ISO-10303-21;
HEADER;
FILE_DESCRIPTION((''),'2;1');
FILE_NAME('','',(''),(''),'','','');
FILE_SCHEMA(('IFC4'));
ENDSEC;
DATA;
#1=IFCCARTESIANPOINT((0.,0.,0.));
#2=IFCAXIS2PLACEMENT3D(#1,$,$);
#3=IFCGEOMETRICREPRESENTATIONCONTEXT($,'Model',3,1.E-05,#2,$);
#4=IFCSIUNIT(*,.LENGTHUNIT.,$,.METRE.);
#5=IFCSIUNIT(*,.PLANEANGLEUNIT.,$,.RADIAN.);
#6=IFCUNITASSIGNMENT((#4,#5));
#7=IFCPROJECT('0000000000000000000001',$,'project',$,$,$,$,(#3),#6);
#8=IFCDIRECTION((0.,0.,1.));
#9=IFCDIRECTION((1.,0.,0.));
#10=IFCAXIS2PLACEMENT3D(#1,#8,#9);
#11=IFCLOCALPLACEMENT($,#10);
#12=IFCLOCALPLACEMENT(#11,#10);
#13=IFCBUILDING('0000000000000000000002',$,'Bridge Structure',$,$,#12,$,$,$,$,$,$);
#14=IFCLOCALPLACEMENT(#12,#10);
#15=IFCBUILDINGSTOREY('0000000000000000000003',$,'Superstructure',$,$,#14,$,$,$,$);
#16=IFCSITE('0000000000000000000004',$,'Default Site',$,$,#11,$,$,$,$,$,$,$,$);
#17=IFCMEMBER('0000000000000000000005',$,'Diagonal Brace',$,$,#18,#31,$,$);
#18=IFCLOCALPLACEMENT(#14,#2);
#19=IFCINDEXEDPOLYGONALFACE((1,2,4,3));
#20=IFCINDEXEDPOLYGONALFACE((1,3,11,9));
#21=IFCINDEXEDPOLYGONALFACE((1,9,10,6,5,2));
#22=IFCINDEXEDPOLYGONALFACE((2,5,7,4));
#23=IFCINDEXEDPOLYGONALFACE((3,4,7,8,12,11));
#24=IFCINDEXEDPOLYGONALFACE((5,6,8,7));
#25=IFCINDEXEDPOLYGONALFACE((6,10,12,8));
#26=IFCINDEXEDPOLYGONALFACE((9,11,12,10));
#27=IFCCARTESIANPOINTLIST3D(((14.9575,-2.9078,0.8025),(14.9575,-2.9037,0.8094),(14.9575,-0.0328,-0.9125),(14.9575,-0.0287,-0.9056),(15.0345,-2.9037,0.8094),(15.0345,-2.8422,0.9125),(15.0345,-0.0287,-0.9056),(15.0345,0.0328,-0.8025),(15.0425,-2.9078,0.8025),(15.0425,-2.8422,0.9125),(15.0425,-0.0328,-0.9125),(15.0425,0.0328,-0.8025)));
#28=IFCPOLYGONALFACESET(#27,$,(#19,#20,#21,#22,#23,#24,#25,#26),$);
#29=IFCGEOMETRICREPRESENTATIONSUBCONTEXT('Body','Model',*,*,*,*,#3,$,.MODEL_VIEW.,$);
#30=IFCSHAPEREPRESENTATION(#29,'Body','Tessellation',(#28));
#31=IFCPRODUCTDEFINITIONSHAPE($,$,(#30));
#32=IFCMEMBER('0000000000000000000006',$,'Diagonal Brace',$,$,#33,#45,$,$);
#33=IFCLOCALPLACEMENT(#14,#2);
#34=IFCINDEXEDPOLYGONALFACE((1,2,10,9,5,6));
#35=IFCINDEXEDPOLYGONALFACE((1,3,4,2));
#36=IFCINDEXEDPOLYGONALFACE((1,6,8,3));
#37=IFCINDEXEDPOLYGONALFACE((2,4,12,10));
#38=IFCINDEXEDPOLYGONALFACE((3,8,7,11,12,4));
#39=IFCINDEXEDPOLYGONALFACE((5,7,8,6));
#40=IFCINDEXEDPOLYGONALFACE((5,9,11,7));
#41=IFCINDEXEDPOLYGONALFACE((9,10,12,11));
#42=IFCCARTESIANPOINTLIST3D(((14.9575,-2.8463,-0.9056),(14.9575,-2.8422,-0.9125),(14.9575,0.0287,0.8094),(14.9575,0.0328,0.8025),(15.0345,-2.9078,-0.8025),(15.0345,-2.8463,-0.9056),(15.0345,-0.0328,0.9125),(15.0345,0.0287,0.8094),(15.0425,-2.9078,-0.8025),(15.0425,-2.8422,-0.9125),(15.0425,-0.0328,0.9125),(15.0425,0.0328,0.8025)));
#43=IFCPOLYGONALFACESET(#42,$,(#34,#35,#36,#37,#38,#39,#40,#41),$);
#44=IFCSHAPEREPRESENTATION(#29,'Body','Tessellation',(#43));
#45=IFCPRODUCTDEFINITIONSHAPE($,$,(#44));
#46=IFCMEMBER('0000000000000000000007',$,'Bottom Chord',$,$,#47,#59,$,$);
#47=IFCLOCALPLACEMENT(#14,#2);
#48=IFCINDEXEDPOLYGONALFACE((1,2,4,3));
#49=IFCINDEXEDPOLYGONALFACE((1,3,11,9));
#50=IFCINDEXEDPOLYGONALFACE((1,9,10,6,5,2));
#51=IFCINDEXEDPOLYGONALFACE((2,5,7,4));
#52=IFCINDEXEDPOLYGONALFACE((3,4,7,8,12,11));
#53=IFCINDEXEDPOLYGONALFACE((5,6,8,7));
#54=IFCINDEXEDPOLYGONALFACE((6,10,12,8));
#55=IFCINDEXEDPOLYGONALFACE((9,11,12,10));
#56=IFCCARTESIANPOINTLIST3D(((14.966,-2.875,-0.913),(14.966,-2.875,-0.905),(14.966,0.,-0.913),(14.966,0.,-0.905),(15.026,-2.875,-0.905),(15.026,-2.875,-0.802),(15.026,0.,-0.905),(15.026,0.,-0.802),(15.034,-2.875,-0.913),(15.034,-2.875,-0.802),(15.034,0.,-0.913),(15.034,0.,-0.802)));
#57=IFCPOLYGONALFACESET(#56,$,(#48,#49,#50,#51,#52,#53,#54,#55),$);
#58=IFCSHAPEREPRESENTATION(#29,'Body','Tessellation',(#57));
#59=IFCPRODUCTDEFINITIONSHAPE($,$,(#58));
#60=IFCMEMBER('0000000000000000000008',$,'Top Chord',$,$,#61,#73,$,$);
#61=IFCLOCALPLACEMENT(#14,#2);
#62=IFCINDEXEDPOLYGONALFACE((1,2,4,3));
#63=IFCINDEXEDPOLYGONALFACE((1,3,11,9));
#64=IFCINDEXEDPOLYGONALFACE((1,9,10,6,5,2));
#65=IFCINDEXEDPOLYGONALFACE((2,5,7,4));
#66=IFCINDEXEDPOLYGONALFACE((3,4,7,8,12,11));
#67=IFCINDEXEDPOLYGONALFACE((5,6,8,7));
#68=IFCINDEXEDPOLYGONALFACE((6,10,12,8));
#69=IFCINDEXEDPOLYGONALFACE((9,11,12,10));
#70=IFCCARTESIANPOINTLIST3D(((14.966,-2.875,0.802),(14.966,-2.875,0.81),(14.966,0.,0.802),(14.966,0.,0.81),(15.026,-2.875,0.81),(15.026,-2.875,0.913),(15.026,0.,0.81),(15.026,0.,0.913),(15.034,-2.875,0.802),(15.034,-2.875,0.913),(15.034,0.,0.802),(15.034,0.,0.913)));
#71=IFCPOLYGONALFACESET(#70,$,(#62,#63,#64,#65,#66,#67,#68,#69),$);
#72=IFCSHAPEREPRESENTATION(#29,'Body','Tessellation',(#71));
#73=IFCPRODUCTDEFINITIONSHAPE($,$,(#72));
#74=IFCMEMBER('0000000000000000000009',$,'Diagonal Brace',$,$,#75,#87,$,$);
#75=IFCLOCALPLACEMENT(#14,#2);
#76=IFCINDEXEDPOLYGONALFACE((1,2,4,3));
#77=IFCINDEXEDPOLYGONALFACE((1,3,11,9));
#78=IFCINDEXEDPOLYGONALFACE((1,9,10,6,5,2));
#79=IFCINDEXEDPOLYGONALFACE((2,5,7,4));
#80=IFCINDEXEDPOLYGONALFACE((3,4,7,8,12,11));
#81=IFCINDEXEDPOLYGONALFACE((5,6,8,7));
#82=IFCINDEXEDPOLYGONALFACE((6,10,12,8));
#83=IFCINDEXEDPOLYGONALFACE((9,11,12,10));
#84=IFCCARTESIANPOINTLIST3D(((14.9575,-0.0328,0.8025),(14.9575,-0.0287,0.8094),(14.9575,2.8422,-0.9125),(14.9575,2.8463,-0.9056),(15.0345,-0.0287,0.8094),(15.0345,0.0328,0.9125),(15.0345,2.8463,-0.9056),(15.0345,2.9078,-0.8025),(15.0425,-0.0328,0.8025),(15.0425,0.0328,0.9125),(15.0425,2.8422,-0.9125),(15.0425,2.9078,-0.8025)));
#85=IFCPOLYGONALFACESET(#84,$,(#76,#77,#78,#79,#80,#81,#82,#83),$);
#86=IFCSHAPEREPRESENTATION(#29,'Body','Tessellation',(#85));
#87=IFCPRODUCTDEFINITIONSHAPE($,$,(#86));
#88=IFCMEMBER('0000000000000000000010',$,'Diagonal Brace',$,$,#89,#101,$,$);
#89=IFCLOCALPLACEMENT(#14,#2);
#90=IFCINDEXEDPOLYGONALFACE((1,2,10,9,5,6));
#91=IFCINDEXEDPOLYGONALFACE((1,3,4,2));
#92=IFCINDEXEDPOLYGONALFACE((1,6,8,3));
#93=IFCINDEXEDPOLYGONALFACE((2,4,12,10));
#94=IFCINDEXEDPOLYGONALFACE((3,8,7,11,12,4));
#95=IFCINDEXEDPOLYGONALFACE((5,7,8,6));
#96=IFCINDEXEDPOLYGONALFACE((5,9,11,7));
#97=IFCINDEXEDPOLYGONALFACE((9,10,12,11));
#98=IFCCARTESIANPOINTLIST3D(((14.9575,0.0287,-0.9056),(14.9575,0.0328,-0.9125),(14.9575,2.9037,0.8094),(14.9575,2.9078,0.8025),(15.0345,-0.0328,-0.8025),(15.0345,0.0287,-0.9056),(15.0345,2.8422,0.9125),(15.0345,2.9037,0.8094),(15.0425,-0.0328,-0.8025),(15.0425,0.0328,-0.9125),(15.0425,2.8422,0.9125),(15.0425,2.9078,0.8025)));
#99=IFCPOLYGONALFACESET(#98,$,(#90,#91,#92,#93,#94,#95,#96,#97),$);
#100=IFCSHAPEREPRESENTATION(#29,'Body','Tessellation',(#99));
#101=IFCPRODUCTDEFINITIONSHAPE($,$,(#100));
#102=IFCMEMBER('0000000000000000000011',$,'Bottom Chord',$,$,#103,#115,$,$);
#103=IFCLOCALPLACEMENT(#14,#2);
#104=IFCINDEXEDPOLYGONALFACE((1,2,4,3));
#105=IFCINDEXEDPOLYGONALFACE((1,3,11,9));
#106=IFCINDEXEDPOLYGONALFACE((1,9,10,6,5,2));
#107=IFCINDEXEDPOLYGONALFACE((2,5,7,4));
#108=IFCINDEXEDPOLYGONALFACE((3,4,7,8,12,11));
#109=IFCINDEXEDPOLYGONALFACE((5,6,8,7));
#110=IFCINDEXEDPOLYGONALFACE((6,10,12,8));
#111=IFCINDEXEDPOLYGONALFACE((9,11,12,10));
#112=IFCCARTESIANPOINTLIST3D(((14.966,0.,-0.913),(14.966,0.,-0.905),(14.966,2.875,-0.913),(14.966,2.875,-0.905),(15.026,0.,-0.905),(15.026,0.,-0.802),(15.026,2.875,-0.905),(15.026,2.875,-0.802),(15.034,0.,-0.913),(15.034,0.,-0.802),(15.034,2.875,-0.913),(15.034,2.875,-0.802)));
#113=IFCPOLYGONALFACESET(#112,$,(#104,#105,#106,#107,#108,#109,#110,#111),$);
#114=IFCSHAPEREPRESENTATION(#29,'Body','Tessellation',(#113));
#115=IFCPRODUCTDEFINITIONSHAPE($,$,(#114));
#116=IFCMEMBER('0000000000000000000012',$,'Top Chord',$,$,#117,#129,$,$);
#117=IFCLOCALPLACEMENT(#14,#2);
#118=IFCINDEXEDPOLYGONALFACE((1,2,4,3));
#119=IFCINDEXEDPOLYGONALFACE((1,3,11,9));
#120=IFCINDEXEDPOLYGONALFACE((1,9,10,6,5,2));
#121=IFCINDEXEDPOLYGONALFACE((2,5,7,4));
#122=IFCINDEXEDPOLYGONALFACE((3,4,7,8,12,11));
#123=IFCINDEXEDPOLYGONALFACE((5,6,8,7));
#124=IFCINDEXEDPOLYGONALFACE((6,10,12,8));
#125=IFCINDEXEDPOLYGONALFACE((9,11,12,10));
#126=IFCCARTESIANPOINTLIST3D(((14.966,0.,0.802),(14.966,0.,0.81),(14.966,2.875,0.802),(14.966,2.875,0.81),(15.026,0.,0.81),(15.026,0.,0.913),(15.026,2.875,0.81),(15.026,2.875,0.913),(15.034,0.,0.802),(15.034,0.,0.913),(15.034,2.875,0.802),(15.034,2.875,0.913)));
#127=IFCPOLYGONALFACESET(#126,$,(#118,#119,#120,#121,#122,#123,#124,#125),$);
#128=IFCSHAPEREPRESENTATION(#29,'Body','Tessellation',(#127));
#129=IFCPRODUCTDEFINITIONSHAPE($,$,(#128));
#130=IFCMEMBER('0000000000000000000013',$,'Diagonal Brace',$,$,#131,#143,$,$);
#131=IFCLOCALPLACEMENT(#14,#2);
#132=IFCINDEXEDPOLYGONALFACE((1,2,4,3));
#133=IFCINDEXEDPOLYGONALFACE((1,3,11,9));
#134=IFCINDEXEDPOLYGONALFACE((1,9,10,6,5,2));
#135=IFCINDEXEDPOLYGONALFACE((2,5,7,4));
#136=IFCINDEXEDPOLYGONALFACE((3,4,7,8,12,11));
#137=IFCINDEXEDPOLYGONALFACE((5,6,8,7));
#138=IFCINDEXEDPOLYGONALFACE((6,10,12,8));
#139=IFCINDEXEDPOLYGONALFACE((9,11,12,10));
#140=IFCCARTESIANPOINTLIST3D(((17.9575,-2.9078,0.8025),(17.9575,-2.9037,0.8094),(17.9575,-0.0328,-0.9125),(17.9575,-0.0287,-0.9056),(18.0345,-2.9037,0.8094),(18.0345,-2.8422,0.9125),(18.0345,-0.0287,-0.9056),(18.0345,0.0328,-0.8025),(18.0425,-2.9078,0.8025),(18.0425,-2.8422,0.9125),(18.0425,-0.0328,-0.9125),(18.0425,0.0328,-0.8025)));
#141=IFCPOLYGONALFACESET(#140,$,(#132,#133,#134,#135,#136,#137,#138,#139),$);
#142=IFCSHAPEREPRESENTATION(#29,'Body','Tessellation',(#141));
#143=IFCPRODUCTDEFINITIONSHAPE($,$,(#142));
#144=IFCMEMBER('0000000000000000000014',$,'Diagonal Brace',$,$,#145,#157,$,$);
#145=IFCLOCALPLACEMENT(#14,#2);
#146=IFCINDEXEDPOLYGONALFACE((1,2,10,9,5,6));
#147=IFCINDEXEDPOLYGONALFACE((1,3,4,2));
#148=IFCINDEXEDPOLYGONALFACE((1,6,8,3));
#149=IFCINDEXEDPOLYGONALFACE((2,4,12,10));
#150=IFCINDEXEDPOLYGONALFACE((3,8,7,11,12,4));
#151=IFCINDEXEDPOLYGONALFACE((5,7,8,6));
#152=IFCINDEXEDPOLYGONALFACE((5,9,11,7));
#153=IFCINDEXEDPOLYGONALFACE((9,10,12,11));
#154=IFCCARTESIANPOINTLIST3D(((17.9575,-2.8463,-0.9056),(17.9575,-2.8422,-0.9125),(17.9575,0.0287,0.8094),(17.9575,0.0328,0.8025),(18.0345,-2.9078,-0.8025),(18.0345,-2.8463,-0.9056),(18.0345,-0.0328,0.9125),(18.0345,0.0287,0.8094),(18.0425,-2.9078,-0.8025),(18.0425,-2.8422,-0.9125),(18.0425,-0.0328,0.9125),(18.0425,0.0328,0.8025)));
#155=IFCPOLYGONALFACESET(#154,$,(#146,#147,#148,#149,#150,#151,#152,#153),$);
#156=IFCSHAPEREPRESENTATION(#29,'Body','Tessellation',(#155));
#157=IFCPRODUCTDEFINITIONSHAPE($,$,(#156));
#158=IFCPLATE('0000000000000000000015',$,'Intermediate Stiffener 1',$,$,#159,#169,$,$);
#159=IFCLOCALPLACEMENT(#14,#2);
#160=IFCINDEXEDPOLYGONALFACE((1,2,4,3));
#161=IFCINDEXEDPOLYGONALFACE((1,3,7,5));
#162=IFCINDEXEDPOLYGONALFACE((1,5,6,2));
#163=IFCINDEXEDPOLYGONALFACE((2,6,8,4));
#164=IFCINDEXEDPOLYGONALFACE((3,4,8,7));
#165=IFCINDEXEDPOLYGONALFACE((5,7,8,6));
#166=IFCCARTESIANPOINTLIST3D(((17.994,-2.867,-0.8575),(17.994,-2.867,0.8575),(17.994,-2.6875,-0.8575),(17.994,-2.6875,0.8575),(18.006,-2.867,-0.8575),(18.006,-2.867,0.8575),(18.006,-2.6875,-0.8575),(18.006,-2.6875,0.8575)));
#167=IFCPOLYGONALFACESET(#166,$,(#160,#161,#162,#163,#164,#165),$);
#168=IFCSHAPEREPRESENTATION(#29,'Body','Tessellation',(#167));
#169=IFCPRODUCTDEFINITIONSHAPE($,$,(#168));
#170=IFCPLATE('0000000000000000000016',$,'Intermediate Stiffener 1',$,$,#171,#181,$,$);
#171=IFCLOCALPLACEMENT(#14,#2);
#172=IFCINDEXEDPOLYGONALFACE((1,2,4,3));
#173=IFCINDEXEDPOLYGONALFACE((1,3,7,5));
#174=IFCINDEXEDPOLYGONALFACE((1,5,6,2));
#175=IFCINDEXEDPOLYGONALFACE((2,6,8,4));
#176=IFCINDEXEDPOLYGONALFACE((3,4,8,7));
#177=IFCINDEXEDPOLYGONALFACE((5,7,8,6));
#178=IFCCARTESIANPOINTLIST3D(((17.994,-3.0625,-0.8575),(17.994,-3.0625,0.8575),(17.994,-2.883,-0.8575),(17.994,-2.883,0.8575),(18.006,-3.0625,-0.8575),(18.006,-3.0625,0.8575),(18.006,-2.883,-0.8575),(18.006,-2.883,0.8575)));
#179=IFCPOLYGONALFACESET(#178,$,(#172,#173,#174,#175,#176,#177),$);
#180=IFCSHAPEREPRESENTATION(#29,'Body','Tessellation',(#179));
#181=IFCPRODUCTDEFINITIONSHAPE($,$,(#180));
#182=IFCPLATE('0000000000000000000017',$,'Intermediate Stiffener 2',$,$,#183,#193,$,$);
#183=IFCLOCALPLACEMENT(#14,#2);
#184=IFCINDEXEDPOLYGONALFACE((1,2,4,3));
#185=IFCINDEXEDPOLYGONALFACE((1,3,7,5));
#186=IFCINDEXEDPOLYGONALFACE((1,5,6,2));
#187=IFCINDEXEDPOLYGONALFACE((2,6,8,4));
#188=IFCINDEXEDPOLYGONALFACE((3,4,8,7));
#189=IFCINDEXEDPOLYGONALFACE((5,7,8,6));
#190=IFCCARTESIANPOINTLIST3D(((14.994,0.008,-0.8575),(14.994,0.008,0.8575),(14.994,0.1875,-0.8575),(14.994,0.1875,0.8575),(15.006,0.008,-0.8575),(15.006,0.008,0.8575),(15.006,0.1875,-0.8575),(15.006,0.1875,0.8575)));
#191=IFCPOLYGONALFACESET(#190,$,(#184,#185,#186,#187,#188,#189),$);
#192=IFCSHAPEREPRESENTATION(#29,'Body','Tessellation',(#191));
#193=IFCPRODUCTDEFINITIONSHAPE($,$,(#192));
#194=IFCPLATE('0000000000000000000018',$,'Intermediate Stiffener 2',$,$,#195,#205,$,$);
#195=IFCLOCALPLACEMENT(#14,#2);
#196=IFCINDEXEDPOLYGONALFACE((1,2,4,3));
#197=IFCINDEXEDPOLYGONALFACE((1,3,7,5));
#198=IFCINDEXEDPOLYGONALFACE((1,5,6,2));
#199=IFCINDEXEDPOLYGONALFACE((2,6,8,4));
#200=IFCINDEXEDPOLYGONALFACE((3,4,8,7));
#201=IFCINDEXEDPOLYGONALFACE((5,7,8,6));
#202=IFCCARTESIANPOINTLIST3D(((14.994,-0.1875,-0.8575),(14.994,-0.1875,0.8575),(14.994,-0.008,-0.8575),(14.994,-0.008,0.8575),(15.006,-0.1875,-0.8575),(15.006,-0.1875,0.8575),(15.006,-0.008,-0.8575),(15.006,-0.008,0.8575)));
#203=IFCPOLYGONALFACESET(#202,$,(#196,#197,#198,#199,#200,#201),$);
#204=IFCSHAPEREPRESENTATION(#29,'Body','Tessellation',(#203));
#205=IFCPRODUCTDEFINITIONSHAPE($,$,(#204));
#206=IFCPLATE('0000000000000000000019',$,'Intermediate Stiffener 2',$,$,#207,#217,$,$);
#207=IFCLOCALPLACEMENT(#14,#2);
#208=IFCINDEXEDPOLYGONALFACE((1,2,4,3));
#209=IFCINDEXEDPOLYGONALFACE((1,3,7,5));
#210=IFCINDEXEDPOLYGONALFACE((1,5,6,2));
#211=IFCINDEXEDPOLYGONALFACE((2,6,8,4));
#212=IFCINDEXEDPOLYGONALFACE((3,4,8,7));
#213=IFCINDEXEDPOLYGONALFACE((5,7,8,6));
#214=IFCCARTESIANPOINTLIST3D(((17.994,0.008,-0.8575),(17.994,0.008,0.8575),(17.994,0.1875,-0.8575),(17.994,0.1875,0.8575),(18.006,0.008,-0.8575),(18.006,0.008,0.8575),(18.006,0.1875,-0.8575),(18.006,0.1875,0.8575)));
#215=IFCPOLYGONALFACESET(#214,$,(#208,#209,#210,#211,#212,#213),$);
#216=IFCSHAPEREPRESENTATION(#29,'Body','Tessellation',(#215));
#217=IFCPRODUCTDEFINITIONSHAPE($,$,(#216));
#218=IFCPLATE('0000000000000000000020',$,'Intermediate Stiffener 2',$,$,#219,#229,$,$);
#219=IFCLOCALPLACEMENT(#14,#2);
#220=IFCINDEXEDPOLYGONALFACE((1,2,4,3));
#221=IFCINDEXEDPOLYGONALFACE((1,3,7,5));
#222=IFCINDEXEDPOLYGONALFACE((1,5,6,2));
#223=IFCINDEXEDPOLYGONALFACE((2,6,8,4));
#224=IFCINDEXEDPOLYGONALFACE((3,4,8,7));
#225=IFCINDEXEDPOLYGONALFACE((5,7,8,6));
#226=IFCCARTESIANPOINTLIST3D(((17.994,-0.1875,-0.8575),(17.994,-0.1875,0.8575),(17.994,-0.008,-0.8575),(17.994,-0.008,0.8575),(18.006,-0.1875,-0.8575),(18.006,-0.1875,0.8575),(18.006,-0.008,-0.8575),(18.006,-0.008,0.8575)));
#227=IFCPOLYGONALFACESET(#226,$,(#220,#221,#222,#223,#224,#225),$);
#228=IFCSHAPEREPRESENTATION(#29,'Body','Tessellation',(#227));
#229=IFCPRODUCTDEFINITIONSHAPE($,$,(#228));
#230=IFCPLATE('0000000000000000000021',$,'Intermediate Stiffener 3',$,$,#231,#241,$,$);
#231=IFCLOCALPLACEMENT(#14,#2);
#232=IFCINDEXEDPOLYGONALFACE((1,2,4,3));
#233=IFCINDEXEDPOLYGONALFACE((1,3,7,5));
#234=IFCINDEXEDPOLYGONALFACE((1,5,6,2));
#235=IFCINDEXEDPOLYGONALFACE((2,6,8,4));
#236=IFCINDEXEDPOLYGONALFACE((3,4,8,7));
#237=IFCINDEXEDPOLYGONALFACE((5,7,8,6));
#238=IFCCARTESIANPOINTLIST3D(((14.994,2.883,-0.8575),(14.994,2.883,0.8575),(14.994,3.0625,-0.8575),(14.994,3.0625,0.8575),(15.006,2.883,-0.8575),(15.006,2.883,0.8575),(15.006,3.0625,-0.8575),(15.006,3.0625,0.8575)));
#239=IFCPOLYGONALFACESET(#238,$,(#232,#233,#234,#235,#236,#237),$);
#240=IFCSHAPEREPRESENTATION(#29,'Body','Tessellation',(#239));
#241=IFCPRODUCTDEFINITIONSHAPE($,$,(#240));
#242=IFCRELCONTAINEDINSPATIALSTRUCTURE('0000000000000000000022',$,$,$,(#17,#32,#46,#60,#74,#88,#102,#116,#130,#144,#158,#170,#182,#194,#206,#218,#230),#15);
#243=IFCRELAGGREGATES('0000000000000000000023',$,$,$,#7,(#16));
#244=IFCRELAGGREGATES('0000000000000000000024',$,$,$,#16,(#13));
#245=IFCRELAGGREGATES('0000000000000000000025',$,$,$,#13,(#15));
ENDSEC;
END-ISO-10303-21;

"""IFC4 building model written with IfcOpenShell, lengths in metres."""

from ifc_helpers import new_model, si_unit, frame, origin, origin_with_axes, origin_2d_with_axis, place, context, subcontext, project, spatial, rectangle, l_section, extrude, element, save


model = new_model("IFC4")

# Units and contexts
model_context = context("Model", 3, precision=1e-05, world=origin())
body_context = subcontext(model_context, "Body", "Model", "MODEL_VIEW")
ifc_project = project(units=[si_unit("LENGTHUNIT", "METRE"), si_unit("PLANEANGLEUNIT", "RADIAN")], contexts=[model_context])

# Site, building, storey
site_placement = place(None, origin_with_axes())
site = spatial("IfcSite", under=ifc_project, at=site_placement, Name="Default Site")
building_placement = place(site_placement, origin_with_axes())
building = spatial("IfcBuilding", under=site, at=building_placement, Name="Bridge Structure")
storey_placement = place(building_placement, origin_with_axes())
storey = spatial("IfcBuildingStorey", under=building, at=storey_placement, Name="Superstructure")

# Members
for number, where, z_axis, x_axis, name in (
    (1, (15.0, -2.875, 0.8575), (0.0, 0.858808, -0.512298), (-1.0, 0.0, 0.0), "Diagonal Brace"),
    (2, (15.0, -2.875, -0.8575), (0.0, 0.858808, 0.512298), (-1.0, 0.0, 0.0), "Diagonal Brace"),
):
    element("IfcMember", number, at=place(storey_placement, frame(where, z_axis=z_axis, x_axis=x_axis)), inside=storey, Name=name, context=body_context, shape_type="SweptSolid", body=[
        extrude(l_section(Depth=0.128, Width=0.085, Thickness=0.008, at=origin_2d_with_axis()), origin_with_axes(), (0.0, 0.0, 1.0), 3.3477),
    ])
for number, where, z_axis, x_axis, name in (
    (3, (15.0, -2.875, -0.8575), (0.0, 1.0, 0.0), (-1.0, 0.0, 0.0), "Bottom Chord"),
    (4, (15.0, -2.875, 0.8575), (0.0, 1.0, 0.0), (-1.0, 0.0, 0.0), "Top Chord"),
):
    element("IfcMember", number, at=place(storey_placement, frame(where, z_axis=z_axis, x_axis=x_axis)), inside=storey, Name=name, context=body_context, shape_type="SweptSolid", body=[
        extrude(l_section(Depth=0.111, Width=0.068, Thickness=0.008, at=origin_2d_with_axis()), origin_with_axes(), (0.0, 0.0, 1.0), 2.875),
    ])
for number, where, z_axis, x_axis, name in (
    (5, (15.0, 0.0, 0.8575), (0.0, 0.858808, -0.512298), (-1.0, 0.0, 0.0), "Diagonal Brace"),
    (6, (15.0, 0.0, -0.8575), (0.0, 0.858808, 0.512298), (-1.0, 0.0, 0.0), "Diagonal Brace"),
):
    element("IfcMember", number, at=place(storey_placement, frame(where, z_axis=z_axis, x_axis=x_axis)), inside=storey, Name=name, context=body_context, shape_type="SweptSolid", body=[
        extrude(l_section(Depth=0.128, Width=0.085, Thickness=0.008, at=origin_2d_with_axis()), origin_with_axes(), (0.0, 0.0, 1.0), 3.3477),
    ])
for number, where, z_axis, x_axis, name in (
    (7, (15.0, 0.0, -0.8575), (0.0, 1.0, 0.0), (-1.0, 0.0, 0.0), "Bottom Chord"),
    (8, (15.0, 0.0, 0.8575), (0.0, 1.0, 0.0), (-1.0, 0.0, 0.0), "Top Chord"),
):
    element("IfcMember", number, at=place(storey_placement, frame(where, z_axis=z_axis, x_axis=x_axis)), inside=storey, Name=name, context=body_context, shape_type="SweptSolid", body=[
        extrude(l_section(Depth=0.111, Width=0.068, Thickness=0.008, at=origin_2d_with_axis()), origin_with_axes(), (0.0, 0.0, 1.0), 2.875),
    ])
for number, where, z_axis, x_axis, name in (
    (9, (18.0, -2.875, 0.8575), (0.0, 0.858808, -0.512298), (-1.0, 0.0, 0.0), "Diagonal Brace"),
    (10, (18.0, -2.875, -0.8575), (0.0, 0.858808, 0.512298), (-1.0, 0.0, 0.0), "Diagonal Brace"),
):
    element("IfcMember", number, at=place(storey_placement, frame(where, z_axis=z_axis, x_axis=x_axis)), inside=storey, Name=name, context=body_context, shape_type="SweptSolid", body=[
        extrude(l_section(Depth=0.128, Width=0.085, Thickness=0.008, at=origin_2d_with_axis()), origin_with_axes(), (0.0, 0.0, 1.0), 3.3477),
    ])

# Plates
for number, where, z_axis, x_axis, name in (
    (11, (18.0, -2.7772, -0.8575), (0.0, 0.0, 1.0), (1.0, 0.0, 0.0), "Intermediate Stiffener 1"),
    (12, (18.0, -2.9728, -0.8575), (0.0, 0.0, 1.0), (1.0, 0.0, 0.0), "Intermediate Stiffener 1"),
    (13, (15.0, 0.0978, -0.8575), (0.0, 0.0, 1.0), (1.0, 0.0, 0.0), "Intermediate Stiffener 2"),
    (14, (15.0, -0.0978, -0.8575), (0.0, 0.0, 1.0), (1.0, 0.0, 0.0), "Intermediate Stiffener 2"),
    (15, (18.0, 0.0978, -0.8575), (0.0, 0.0, 1.0), (1.0, 0.0, 0.0), "Intermediate Stiffener 2"),
    (16, (18.0, -0.0978, -0.8575), (0.0, 0.0, 1.0), (1.0, 0.0, 0.0), "Intermediate Stiffener 2"),
    (17, (15.0, 2.9728, -0.8575), (0.0, 0.0, 1.0), (1.0, 0.0, 0.0), "Intermediate Stiffener 3"),
):
    element("IfcPlate", number, at=place(storey_placement, frame(where, z_axis=z_axis, x_axis=x_axis)), inside=storey, Name=name, context=body_context, shape_type="SweptSolid", body=[
        extrude(rectangle(XDim=0.012, YDim=0.1795, at=origin_2d_with_axis()), origin_with_axes(), (0.0, 0.0, 1.0), 1.715),
    ])

save(model, "model.ifc")
